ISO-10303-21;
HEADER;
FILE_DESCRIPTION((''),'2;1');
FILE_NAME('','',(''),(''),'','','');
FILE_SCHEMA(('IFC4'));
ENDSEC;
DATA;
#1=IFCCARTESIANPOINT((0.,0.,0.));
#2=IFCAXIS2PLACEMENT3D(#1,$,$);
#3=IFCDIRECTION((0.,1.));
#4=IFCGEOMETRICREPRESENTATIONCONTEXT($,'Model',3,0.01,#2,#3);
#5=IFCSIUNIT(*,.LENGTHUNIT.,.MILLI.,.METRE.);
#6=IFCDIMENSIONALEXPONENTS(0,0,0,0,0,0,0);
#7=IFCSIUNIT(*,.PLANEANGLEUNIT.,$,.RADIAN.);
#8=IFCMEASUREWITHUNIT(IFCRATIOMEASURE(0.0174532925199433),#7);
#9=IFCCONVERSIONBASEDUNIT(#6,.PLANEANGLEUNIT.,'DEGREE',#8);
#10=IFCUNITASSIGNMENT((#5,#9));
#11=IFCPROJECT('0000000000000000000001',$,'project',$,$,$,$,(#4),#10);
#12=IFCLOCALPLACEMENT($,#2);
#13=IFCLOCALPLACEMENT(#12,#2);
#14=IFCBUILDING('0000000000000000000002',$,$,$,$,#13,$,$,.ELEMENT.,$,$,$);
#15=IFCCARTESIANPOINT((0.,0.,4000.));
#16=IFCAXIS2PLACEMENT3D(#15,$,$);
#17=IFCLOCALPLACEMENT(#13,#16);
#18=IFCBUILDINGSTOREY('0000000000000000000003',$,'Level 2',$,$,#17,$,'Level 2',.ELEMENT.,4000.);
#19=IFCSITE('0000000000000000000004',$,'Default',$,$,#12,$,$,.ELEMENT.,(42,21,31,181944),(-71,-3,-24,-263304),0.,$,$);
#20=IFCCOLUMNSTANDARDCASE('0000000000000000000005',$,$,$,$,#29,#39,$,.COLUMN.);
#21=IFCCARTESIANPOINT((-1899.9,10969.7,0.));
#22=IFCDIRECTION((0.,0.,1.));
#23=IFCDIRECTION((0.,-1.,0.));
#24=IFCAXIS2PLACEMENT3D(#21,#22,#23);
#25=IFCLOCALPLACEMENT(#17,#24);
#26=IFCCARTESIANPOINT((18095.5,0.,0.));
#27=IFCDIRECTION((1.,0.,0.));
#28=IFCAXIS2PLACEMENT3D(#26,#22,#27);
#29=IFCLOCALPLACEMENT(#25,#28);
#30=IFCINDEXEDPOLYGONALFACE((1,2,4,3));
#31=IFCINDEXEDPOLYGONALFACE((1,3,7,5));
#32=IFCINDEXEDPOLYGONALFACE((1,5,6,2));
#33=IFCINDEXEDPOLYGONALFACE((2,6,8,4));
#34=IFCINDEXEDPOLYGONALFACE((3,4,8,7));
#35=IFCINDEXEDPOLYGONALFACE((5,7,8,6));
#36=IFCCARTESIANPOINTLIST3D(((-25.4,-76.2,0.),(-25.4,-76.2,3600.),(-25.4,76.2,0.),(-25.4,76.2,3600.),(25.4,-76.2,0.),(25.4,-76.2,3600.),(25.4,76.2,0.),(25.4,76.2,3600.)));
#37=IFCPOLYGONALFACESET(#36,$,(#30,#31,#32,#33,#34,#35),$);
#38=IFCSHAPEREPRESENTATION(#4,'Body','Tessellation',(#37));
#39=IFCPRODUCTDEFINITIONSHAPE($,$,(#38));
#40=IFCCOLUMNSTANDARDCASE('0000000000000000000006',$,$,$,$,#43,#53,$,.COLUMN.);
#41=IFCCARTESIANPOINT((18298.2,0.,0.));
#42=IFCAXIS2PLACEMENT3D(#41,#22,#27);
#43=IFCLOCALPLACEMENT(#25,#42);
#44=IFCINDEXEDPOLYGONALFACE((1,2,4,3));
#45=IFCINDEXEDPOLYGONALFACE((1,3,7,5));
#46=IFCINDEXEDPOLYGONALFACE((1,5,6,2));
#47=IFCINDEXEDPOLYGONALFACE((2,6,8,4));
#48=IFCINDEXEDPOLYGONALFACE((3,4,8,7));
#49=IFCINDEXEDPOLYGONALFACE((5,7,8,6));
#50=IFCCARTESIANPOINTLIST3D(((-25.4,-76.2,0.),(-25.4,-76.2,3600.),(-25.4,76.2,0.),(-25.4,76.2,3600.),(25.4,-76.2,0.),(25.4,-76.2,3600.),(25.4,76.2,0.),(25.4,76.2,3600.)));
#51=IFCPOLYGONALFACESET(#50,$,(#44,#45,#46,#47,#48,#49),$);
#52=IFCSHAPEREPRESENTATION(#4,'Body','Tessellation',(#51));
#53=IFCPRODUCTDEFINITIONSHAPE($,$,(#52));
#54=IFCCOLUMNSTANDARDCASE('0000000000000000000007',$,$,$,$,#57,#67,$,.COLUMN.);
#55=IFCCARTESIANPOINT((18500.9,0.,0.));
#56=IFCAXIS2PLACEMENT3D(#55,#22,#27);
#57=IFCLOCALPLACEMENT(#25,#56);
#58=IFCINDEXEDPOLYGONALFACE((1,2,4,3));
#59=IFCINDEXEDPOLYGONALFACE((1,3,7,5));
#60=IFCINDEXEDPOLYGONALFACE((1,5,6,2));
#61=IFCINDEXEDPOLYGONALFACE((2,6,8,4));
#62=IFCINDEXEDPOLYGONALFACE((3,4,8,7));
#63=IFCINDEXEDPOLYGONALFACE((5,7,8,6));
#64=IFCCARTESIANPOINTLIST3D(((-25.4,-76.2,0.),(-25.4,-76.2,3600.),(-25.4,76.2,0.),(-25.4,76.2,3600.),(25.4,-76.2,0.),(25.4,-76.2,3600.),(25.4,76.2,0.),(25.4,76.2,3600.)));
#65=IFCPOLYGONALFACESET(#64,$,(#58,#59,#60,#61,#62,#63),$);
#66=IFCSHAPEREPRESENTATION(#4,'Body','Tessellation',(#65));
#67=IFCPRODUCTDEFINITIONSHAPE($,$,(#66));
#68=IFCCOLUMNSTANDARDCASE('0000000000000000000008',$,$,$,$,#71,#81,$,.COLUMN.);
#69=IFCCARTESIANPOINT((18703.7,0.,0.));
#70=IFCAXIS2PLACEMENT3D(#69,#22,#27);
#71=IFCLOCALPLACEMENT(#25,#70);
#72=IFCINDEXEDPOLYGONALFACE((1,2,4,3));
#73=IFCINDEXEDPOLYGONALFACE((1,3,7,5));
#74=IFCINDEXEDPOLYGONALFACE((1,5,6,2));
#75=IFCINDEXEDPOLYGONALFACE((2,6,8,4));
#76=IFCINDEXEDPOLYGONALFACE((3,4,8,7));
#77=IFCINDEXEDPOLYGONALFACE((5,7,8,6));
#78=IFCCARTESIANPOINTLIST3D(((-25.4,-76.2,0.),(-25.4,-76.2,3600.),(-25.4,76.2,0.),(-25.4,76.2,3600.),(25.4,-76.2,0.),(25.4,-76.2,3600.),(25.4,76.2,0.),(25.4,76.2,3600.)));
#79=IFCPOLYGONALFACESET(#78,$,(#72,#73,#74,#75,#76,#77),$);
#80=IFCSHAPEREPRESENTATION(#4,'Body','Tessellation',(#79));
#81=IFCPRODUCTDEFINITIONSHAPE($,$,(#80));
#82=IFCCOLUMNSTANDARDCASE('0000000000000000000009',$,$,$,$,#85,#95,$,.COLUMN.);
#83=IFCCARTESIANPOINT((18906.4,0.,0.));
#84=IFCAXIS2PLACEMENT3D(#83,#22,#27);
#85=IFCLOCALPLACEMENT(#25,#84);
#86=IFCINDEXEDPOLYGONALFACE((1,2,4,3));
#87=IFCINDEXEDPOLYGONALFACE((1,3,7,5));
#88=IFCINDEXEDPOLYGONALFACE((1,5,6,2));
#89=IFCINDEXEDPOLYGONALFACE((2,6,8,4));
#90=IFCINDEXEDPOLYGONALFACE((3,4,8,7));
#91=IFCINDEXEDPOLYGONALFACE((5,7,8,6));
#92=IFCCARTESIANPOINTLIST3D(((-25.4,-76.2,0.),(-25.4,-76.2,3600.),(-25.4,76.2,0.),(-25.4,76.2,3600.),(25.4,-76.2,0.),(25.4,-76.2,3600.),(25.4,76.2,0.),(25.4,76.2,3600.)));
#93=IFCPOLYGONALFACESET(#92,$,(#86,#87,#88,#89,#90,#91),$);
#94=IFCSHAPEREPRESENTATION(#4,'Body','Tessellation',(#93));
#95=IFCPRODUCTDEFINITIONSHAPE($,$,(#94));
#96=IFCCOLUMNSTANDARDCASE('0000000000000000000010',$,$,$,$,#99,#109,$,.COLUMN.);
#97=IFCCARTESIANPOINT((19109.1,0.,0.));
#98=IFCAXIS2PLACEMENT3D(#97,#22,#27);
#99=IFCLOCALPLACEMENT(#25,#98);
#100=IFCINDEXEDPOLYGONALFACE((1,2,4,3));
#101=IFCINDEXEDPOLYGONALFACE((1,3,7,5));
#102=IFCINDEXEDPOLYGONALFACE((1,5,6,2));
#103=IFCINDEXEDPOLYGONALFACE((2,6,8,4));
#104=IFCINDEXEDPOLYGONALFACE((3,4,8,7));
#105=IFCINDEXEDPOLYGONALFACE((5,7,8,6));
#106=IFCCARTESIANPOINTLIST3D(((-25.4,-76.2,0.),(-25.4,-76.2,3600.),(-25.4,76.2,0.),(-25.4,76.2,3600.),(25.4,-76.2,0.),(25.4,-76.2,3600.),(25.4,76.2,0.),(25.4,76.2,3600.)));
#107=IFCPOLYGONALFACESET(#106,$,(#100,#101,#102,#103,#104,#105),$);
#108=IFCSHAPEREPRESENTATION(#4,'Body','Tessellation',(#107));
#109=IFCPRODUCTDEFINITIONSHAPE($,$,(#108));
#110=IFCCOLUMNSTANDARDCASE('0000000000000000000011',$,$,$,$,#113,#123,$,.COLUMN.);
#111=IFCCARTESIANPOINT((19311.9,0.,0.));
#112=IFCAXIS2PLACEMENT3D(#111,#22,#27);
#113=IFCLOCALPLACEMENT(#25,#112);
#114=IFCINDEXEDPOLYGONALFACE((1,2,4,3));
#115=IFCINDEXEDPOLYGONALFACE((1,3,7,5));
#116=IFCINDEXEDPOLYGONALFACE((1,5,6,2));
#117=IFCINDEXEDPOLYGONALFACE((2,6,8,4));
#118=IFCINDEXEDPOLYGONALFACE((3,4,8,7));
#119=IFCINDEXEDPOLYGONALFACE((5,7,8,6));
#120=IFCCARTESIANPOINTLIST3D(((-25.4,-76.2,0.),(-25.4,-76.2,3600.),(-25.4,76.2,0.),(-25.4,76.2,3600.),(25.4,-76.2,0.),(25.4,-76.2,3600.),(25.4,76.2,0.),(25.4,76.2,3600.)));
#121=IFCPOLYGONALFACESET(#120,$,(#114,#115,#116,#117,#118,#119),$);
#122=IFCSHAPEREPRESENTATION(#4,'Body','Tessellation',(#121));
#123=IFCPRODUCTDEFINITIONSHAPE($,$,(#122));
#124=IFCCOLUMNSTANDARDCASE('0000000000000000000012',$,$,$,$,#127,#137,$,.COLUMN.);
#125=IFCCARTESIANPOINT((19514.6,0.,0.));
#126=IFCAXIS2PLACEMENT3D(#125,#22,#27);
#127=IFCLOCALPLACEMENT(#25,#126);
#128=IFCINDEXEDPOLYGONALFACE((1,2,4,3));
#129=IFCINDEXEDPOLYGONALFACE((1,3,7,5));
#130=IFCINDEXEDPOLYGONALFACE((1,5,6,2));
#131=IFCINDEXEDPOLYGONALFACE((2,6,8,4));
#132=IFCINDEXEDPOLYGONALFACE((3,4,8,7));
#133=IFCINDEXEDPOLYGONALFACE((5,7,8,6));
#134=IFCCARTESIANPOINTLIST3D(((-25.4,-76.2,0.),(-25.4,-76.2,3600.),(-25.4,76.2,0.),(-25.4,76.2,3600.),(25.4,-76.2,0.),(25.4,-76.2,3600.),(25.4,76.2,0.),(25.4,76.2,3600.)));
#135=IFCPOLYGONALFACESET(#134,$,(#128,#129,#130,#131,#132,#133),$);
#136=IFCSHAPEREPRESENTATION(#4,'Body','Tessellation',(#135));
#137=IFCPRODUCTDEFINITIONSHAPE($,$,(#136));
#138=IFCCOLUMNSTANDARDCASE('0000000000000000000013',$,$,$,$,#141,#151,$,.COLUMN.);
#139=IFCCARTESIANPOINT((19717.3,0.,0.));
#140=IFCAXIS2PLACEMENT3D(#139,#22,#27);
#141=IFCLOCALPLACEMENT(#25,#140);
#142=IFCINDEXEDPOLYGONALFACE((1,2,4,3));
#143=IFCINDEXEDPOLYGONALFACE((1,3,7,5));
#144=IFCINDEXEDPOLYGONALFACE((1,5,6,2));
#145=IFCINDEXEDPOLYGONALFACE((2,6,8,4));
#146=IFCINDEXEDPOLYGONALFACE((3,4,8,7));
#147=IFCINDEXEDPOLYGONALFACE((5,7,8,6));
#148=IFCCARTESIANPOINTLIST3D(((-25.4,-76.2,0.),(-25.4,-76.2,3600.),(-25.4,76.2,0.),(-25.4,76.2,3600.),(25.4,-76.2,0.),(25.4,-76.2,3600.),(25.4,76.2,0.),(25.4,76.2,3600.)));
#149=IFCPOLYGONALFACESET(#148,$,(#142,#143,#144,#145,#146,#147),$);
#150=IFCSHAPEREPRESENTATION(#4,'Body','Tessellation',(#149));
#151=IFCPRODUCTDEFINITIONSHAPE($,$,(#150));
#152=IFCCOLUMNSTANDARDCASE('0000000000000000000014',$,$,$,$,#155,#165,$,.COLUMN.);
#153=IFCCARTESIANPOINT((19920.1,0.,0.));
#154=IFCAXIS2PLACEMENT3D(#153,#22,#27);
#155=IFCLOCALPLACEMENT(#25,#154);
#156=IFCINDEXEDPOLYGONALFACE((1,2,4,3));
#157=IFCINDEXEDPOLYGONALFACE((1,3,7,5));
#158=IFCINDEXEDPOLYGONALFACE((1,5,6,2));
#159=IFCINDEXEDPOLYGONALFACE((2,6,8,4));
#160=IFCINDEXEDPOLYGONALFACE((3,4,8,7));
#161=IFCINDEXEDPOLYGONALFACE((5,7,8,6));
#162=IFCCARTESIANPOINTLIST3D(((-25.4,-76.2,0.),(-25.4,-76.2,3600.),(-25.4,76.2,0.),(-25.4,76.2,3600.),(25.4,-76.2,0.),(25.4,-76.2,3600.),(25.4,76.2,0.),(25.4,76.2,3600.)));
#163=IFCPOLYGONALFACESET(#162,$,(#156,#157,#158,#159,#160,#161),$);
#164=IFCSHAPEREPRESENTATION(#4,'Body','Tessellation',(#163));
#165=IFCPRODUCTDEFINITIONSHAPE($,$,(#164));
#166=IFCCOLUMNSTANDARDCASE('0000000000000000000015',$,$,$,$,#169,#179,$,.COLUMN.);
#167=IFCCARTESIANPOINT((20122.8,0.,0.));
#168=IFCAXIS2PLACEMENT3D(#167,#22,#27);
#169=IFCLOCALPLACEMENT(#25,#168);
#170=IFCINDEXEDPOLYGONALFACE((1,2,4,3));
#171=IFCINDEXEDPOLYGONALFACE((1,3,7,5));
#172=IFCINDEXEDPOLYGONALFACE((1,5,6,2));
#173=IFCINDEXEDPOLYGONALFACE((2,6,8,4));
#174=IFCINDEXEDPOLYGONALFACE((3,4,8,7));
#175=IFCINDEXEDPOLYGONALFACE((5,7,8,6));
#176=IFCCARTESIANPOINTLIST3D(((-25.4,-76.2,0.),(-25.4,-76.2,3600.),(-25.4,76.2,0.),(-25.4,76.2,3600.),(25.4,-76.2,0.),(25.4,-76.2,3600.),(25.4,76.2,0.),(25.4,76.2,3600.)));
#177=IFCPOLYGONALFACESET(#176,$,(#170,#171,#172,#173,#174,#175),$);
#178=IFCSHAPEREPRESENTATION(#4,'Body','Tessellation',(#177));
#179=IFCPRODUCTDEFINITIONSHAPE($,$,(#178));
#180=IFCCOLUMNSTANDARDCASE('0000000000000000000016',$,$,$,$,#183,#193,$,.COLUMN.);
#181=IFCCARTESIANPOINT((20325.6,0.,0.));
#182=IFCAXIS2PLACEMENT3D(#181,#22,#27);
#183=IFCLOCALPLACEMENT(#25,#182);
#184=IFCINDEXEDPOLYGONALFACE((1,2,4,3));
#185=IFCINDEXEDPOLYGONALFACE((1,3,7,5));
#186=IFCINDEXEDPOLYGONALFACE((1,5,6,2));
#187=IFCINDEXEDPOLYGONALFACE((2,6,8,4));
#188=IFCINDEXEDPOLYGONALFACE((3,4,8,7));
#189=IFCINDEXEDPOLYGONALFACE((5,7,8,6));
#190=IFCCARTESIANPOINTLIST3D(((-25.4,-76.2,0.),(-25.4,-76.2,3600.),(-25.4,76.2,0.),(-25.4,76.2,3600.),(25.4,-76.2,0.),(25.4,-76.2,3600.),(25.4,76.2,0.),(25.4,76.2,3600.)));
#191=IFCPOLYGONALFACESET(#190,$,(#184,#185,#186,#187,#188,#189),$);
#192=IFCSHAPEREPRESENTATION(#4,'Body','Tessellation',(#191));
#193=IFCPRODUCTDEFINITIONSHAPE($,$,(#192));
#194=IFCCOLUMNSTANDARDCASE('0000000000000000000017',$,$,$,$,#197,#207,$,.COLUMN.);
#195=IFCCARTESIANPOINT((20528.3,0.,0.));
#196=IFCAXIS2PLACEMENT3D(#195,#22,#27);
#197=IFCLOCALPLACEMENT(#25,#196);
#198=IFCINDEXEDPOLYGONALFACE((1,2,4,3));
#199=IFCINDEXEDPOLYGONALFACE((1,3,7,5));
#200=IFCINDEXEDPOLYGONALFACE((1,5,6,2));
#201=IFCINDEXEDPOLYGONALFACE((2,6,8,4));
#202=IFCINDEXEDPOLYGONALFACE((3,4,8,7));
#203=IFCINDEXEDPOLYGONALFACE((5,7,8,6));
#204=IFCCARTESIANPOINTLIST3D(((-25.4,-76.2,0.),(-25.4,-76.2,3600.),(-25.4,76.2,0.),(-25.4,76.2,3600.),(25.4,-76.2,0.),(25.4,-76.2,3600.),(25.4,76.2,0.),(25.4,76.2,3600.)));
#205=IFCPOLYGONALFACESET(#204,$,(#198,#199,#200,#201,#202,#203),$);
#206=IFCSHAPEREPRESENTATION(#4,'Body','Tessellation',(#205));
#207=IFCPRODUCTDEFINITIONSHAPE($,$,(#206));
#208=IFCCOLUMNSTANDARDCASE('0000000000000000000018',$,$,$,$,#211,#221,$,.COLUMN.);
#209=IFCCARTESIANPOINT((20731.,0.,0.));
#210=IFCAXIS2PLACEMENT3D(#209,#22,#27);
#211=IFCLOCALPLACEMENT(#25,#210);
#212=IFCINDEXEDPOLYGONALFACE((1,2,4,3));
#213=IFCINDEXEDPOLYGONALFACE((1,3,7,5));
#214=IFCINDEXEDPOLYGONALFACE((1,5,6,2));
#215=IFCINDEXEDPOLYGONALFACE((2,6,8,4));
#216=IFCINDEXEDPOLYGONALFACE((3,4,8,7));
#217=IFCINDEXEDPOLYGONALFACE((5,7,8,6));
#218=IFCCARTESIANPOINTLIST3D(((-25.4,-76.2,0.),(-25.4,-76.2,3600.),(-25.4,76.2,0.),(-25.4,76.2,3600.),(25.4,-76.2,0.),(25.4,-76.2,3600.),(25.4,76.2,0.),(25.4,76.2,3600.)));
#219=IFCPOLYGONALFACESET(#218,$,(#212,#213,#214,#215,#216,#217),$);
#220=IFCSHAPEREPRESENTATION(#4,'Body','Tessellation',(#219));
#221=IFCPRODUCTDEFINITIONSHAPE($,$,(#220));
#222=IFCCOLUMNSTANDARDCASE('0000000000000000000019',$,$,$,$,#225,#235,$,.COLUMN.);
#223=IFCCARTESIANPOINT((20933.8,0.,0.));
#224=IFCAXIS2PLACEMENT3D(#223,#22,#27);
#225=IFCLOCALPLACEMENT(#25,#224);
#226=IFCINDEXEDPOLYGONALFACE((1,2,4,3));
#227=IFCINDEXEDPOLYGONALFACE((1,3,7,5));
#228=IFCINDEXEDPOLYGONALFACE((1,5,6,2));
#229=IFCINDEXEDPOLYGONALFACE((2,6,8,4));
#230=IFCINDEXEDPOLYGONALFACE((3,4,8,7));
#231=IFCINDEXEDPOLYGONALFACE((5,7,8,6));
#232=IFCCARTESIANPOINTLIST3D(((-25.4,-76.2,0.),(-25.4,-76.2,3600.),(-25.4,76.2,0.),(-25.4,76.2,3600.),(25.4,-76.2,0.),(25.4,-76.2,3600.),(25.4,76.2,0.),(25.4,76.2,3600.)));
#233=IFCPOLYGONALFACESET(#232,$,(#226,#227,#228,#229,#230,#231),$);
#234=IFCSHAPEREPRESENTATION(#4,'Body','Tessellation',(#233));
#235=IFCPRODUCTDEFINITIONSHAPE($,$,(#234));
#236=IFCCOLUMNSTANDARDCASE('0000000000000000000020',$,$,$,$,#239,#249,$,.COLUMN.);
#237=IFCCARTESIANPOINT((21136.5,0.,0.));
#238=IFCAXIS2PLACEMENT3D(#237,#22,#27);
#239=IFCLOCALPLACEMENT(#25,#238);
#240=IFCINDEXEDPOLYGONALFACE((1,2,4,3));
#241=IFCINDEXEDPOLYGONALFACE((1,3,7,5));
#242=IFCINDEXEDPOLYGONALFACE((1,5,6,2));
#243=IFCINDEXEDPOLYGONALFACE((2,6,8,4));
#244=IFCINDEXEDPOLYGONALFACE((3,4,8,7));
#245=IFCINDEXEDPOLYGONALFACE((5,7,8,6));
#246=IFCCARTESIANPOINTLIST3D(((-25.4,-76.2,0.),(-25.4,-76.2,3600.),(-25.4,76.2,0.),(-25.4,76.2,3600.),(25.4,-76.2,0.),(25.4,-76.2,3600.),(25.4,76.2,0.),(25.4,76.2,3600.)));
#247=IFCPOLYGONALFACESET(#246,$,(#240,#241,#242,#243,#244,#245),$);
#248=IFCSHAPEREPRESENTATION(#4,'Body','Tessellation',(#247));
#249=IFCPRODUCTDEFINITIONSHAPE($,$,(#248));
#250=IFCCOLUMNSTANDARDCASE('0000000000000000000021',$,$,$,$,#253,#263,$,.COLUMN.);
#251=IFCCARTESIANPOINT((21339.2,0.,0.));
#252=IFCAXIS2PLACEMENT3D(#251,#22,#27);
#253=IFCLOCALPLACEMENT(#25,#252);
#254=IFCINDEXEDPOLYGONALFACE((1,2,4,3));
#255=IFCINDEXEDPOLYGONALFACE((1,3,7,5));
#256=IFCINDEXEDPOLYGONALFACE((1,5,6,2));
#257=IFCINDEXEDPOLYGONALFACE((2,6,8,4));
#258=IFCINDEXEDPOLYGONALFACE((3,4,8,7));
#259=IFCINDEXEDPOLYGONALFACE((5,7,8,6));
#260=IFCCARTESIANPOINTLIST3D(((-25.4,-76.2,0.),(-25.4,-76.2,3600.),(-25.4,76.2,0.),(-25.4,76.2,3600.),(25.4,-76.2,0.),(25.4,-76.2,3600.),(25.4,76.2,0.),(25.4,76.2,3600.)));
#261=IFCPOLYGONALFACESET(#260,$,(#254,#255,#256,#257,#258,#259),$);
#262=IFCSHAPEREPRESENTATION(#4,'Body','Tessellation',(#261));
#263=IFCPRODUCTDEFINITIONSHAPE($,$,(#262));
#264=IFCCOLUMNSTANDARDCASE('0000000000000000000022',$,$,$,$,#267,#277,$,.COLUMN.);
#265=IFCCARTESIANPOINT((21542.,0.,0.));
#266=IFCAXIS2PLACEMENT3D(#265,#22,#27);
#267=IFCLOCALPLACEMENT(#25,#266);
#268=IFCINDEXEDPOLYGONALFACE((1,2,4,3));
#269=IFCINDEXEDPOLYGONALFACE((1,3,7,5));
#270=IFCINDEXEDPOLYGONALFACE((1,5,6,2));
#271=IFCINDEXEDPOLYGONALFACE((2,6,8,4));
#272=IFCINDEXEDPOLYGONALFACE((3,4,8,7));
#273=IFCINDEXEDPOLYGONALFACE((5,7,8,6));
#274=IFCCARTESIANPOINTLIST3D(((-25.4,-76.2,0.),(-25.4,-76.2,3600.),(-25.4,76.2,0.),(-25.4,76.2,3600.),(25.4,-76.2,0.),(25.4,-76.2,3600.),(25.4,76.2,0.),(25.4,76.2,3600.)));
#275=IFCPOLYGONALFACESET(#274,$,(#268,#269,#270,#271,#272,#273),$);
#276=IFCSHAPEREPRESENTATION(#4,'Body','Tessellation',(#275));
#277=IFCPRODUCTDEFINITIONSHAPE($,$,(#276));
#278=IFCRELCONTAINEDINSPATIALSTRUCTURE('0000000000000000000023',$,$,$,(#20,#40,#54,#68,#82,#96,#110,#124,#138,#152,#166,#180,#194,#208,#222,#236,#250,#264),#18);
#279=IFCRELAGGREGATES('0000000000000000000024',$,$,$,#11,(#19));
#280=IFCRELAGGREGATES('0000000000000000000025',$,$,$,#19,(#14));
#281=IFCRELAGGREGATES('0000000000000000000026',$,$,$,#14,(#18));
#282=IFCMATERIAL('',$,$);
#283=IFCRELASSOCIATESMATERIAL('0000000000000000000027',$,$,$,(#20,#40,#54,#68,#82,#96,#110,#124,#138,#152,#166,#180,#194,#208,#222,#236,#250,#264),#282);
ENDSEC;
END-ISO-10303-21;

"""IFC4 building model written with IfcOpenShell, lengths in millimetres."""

from ifc_helpers import new_model, entity, si_unit, converted_unit, direction, frame, origin, place, context, project, spatial, rectangle, extrude, material, element, save


model = new_model("IFC4")

# Units and contexts
model_context = context("Model", 3, precision=0.01, world=origin(), true_north=direction((0.0, 1.0)))
ifc_project = project(units=[si_unit("LENGTHUNIT", "METRE", prefix="MILLI"), converted_unit("PLANEANGLEUNIT", "DEGREE", entity("IfcRatioMeasure", 0.0174532925199433), si_unit("PLANEANGLEUNIT", "RADIAN"), dimensions=[0, 0, 0, 0, 0, 0, 0])], contexts=[model_context])

# Site, building, storey
site_placement = place(None, origin())
site = spatial("IfcSite", under=ifc_project, at=site_placement, Name="Default", CompositionType="ELEMENT", RefLatitude=(42, 21, 31, 181944), RefLongitude=(-71, -3, -24, -263304), RefElevation=0.0)
building_placement = place(site_placement, origin())
building = spatial("IfcBuilding", under=site, at=building_placement, CompositionType="ELEMENT")
storey_placement = place(building_placement, frame((0.0, 0.0, 4000.0)))
storey = spatial("IfcBuildingStorey", under=building, at=storey_placement, Name="Level 2", LongName="Level 2", CompositionType="ELEMENT", Elevation=4000.0)

# Columns
ifc_material = material(Name="")
placement = place(storey_placement, frame((-1899.9, 10969.7, 0.0), z_axis=(0.0, 0.0, 1.0), x_axis=(0.0, -1.0, 0.0)))
for number, where, z_axis, x_axis in (
    (1, (18095.5, 0.0, 0.0), (0.0, 0.0, 1.0), (1.0, 0.0, 0.0)),
    (2, (18298.2, 0.0, 0.0), (0.0, 0.0, 1.0), (1.0, 0.0, 0.0)),
    (3, (18500.9, 0.0, 0.0), (0.0, 0.0, 1.0), (1.0, 0.0, 0.0)),
    (4, (18703.7, 0.0, 0.0), (0.0, 0.0, 1.0), (1.0, 0.0, 0.0)),
    (5, (18906.4, 0.0, 0.0), (0.0, 0.0, 1.0), (1.0, 0.0, 0.0)),
    (6, (19109.1, 0.0, 0.0), (0.0, 0.0, 1.0), (1.0, 0.0, 0.0)),
    (7, (19311.9, 0.0, 0.0), (0.0, 0.0, 1.0), (1.0, 0.0, 0.0)),
    (8, (19514.6, 0.0, 0.0), (0.0, 0.0, 1.0), (1.0, 0.0, 0.0)),
    (9, (19717.3, 0.0, 0.0), (0.0, 0.0, 1.0), (1.0, 0.0, 0.0)),
    (10, (19920.1, 0.0, 0.0), (0.0, 0.0, 1.0), (1.0, 0.0, 0.0)),
    (11, (20122.8, 0.0, 0.0), (0.0, 0.0, 1.0), (1.0, 0.0, 0.0)),
    (12, (20325.6, 0.0, 0.0), (0.0, 0.0, 1.0), (1.0, 0.0, 0.0)),
    (13, (20528.3, 0.0, 0.0), (0.0, 0.0, 1.0), (1.0, 0.0, 0.0)),
    (14, (20731.0, 0.0, 0.0), (0.0, 0.0, 1.0), (1.0, 0.0, 0.0)),
    (15, (20933.8, 0.0, 0.0), (0.0, 0.0, 1.0), (1.0, 0.0, 0.0)),
    (16, (21136.5, 0.0, 0.0), (0.0, 0.0, 1.0), (1.0, 0.0, 0.0)),
    (17, (21339.2, 0.0, 0.0), (0.0, 0.0, 1.0), (1.0, 0.0, 0.0)),
    (18, (21542.0, 0.0, 0.0), (0.0, 0.0, 1.0), (1.0, 0.0, 0.0)),
):
    element("IfcColumnStandardCase", number, at=place(placement, frame(where, z_axis=z_axis, x_axis=x_axis)), inside=storey, material=ifc_material, PredefinedType="COLUMN", context=model_context, shape_type="SweptSolid", body=[
        extrude(rectangle(XDim=50.8, YDim=152.4), origin(), (0.0, 0.0, 1.0), 3600.0),
    ])

save(model, "model.ifc")
